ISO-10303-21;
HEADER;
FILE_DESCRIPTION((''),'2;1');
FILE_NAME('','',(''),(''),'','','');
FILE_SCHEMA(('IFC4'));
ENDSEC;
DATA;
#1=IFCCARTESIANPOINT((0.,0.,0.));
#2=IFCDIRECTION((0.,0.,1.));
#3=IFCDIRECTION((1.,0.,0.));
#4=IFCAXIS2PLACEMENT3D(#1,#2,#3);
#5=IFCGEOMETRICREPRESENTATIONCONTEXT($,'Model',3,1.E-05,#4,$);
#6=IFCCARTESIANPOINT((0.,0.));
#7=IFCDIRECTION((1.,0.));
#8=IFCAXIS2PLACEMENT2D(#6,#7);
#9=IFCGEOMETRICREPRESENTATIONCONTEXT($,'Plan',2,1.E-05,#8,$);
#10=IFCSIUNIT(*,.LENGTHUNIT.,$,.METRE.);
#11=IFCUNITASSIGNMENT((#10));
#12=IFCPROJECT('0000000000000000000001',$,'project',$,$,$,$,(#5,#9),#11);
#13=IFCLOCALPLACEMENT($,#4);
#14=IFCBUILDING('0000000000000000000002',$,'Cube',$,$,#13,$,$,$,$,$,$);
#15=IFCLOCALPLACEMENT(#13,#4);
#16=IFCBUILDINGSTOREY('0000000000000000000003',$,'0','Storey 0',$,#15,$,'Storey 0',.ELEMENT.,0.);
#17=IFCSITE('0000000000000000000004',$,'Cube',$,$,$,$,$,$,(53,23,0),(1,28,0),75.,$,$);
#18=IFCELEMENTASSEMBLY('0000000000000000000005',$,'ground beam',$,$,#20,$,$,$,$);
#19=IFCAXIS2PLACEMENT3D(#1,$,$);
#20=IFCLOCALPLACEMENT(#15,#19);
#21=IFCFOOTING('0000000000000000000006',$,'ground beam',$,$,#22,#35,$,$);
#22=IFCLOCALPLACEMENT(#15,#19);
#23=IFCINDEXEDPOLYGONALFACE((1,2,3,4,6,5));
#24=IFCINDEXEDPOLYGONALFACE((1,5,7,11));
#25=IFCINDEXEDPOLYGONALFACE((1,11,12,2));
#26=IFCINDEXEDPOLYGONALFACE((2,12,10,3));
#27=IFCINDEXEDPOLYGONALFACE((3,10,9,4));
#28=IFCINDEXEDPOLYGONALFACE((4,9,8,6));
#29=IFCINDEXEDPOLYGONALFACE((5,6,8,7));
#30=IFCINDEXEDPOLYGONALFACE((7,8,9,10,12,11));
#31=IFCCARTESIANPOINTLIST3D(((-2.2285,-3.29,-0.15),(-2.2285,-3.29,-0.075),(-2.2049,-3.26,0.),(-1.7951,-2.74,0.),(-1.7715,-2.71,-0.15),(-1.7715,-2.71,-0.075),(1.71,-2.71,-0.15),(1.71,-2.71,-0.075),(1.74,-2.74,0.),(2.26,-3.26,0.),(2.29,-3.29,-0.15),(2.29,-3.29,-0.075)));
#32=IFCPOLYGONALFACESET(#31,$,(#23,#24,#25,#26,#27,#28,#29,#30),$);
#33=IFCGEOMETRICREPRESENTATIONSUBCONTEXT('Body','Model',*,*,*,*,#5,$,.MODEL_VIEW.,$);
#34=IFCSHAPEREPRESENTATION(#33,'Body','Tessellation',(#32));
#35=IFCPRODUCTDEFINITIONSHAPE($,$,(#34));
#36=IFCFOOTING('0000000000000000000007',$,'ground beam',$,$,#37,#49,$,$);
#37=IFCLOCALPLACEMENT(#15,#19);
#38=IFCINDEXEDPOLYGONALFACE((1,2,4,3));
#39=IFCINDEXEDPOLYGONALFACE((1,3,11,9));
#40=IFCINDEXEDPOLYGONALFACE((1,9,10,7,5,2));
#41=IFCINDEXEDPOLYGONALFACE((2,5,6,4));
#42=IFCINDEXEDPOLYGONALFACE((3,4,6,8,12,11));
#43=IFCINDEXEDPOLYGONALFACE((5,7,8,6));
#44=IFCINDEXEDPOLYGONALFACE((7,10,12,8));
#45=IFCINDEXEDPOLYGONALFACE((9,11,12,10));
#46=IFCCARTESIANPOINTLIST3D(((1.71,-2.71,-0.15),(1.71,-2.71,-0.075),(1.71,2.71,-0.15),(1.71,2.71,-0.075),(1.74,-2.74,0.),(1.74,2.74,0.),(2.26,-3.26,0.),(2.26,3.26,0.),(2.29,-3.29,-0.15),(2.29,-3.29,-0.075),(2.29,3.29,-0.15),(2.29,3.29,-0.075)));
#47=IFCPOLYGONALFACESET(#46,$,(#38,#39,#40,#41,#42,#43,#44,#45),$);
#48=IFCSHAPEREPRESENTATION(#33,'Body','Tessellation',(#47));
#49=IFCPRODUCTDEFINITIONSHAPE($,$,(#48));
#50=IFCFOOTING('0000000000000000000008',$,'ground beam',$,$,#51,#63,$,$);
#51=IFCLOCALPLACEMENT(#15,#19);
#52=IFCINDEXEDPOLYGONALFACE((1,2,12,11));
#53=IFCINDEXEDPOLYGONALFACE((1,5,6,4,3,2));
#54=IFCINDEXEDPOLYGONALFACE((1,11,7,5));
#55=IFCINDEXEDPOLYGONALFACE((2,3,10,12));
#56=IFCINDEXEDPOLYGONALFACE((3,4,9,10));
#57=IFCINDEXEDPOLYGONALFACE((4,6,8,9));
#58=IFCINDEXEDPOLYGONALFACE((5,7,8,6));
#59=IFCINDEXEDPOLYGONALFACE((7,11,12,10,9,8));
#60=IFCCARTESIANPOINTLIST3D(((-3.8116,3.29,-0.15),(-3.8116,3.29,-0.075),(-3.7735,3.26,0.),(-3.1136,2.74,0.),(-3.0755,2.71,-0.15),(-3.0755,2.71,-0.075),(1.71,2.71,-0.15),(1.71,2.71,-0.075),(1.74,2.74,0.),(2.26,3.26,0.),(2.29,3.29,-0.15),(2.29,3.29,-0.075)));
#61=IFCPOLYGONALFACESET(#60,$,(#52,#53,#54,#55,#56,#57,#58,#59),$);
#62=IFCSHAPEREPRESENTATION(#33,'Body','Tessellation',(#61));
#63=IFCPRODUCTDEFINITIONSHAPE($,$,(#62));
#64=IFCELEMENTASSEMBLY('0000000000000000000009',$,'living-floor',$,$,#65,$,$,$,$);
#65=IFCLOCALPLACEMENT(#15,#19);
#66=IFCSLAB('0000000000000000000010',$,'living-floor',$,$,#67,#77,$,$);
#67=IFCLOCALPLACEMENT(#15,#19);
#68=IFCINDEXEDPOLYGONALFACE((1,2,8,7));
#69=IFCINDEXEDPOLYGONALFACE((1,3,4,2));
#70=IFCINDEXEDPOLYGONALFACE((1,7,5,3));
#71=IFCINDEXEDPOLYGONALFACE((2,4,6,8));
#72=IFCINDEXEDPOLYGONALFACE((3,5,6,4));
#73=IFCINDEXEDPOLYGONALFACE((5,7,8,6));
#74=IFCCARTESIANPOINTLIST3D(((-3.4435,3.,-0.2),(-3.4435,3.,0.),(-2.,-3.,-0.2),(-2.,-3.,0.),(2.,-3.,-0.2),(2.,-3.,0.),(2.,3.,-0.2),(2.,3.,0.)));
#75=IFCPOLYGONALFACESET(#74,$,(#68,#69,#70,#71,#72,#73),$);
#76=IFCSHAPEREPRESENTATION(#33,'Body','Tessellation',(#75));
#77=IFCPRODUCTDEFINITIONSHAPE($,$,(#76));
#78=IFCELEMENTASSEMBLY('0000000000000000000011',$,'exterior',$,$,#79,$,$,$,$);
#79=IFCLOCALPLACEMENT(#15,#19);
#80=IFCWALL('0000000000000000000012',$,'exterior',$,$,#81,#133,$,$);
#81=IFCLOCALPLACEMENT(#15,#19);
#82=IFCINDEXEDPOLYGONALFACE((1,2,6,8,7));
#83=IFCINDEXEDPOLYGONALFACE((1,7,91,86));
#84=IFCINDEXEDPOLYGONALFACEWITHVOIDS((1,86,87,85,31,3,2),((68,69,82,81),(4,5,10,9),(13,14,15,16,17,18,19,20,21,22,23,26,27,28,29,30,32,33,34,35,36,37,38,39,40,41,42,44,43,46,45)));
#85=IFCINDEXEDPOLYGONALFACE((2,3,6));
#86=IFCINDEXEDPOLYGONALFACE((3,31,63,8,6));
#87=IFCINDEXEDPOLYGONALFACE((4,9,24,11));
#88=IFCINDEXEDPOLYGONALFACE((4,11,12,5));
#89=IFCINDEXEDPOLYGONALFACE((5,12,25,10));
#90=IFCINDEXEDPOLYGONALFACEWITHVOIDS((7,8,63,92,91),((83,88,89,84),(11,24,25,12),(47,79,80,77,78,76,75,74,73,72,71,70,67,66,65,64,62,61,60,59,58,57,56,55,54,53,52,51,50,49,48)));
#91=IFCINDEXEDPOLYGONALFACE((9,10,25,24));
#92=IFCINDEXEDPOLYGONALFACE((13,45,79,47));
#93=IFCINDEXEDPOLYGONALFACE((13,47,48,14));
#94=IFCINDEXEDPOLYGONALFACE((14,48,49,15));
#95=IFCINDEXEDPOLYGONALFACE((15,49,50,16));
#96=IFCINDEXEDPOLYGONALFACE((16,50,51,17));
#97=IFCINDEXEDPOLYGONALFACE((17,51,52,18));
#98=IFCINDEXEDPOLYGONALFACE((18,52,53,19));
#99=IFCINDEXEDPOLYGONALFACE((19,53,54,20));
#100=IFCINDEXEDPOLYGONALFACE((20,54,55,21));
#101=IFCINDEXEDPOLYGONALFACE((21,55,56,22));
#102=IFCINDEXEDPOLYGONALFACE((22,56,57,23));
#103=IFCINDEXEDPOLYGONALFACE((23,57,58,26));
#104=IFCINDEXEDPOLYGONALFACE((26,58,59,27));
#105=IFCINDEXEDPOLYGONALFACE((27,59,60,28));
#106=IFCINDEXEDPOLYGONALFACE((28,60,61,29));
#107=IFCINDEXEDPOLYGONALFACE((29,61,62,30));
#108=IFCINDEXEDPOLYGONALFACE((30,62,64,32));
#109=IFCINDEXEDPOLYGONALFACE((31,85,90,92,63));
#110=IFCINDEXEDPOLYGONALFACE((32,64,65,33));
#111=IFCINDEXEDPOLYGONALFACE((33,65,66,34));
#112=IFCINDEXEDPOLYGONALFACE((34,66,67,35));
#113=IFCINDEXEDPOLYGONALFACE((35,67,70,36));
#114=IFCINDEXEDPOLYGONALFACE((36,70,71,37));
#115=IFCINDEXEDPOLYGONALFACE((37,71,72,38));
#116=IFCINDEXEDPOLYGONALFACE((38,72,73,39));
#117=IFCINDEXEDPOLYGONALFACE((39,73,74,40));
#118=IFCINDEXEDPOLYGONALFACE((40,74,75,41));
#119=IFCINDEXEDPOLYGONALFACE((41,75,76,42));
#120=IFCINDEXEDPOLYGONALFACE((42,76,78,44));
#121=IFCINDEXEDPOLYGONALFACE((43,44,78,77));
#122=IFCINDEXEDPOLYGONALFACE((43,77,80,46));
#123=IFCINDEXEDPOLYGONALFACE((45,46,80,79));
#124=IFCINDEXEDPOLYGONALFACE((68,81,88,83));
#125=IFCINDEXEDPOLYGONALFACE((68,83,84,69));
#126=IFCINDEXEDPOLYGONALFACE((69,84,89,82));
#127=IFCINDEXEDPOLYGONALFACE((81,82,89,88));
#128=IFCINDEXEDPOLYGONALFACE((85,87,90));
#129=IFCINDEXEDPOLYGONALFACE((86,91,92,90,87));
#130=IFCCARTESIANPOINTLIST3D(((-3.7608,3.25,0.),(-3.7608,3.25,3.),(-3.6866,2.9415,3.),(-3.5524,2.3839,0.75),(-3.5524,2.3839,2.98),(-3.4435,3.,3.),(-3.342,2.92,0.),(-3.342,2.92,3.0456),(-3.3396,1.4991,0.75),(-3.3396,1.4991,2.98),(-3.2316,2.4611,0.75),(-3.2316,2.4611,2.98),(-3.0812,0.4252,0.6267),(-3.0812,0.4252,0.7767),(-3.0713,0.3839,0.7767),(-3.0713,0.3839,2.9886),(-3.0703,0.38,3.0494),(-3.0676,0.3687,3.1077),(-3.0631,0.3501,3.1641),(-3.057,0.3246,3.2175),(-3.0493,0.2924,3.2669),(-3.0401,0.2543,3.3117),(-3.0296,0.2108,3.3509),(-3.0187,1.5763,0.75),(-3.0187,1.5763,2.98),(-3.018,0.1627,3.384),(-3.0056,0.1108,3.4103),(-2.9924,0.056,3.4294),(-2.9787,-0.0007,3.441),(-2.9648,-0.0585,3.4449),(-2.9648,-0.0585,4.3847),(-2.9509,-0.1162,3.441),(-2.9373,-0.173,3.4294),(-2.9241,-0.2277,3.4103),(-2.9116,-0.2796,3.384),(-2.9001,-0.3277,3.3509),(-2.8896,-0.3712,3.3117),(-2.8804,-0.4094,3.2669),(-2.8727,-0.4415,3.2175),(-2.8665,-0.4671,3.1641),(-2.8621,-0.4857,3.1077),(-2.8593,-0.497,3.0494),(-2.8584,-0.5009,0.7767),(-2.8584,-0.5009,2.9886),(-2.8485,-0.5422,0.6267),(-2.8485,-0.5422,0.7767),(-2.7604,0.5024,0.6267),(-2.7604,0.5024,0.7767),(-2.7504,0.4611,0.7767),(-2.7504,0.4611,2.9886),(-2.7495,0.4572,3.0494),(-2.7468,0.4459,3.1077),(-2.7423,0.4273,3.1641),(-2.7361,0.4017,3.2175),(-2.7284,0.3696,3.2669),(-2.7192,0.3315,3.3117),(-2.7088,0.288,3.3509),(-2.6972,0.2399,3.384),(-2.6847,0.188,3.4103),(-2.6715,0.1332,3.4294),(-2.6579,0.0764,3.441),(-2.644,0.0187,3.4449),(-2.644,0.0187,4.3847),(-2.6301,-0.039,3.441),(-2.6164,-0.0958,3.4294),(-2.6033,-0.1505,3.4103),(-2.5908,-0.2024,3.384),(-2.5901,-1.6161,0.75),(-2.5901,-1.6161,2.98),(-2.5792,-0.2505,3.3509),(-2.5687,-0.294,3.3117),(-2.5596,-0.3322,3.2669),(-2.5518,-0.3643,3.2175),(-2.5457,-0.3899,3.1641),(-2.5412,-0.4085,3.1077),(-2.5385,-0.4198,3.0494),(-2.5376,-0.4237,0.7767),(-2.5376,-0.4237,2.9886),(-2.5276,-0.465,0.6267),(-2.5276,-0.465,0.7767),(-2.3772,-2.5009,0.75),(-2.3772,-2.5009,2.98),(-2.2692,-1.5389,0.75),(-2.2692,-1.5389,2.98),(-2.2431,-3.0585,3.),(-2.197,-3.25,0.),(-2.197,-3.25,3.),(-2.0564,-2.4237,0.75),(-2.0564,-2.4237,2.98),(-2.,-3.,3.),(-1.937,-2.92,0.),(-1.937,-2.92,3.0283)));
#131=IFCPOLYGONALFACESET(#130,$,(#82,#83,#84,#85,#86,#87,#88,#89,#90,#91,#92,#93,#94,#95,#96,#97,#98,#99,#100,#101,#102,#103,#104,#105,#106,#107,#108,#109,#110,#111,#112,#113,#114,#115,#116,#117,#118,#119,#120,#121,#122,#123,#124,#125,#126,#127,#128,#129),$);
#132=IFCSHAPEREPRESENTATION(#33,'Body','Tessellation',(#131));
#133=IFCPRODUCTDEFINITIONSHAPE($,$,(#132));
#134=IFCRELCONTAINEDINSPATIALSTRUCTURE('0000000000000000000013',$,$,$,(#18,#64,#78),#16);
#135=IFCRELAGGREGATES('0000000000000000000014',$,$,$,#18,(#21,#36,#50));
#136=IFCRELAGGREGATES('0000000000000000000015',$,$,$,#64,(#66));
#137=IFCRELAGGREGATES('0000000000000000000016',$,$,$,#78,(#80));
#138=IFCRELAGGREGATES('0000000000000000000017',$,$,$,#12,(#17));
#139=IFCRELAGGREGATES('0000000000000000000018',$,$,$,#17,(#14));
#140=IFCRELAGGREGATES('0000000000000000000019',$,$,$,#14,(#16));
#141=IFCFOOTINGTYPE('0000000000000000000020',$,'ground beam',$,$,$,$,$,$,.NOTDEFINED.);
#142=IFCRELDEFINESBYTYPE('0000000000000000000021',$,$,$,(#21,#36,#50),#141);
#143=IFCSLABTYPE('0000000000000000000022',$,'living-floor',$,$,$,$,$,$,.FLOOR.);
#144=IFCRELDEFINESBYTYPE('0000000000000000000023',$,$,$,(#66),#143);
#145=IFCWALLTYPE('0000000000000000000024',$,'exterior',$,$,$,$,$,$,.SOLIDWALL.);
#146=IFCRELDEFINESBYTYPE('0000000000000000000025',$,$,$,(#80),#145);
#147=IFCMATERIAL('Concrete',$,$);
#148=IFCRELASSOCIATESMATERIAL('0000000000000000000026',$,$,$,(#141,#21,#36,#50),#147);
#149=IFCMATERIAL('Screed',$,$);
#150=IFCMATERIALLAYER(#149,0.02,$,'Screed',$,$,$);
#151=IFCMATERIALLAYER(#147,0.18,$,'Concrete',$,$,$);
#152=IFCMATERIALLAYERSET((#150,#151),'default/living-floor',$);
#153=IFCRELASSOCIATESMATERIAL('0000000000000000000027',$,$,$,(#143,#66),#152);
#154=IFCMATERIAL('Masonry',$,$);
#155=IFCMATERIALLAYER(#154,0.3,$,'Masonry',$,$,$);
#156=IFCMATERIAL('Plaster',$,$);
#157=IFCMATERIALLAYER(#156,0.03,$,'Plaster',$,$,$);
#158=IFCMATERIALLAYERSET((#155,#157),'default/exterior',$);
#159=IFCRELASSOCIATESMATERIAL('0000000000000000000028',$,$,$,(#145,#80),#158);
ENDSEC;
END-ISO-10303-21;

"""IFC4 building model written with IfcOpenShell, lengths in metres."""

from ifc_helpers import new_model, si_unit, frame, origin, origin_with_axes, origin_2d_with_axis, place, context, subcontext, project, spatial, polyline, outline, extrude, clip, halfspace, bounded_halfspace, material, layer, layer_set, layer_usage, material_profile, profile_set, profile_usage, type_object, element, aggregate, save


model = new_model("IFC4")

# Units and contexts
model_context = context("Model", 3, precision=1e-05, world=origin_with_axes())
plan_context = context("Plan", 2, precision=1e-05, world=origin_2d_with_axis())
body_context = subcontext(model_context, "Body", "Model", "MODEL_VIEW")
ifc_project = project(units=[si_unit("LENGTHUNIT", "METRE")], contexts=[model_context, plan_context])

# Site, building, storey
site = spatial("IfcSite", under=ifc_project, Name="Cube", RefLatitude=(53, 23, 0), RefLongitude=(1, 28, 0), RefElevation=75.0)
building_placement = place(None, origin_with_axes())
building = spatial("IfcBuilding", under=site, at=building_placement, Name="Cube")
storey_placement = place(building_placement, origin_with_axes())
storey = spatial("IfcBuildingStorey", under=building, at=storey_placement, Name="0", Description="Storey 0", LongName="Storey 0", CompositionType="ELEMENT", Elevation=0.0)

# Element assembly, footings
assembly_1_placement = place(storey_placement, origin_with_axes())
assembly_1 = element("IfcElementAssembly", 1, at=assembly_1_placement, inside=storey, Name="ground beam")
ifc_material_1 = material(Name="Concrete")
ifc_material_profile = material_profile(ifc_material_1, outline(polyline([(-0.26, 0.0), (-0.29, -0.075), (-0.29, -0.15), (0.29, -0.15), (0.29, -0.075), (0.26, 0.0), (-0.26, 0.0)])))
ifc_profile_set = profile_set([ifc_material_profile])
ifc_profile_usage_1 = profile_usage(ifc_profile_set)
footing_type = type_object("IfcFootingType", Name="ground beam", PredefinedType="NOTDEFINED", material=ifc_profile_set)
footing_1_placement = place(assembly_1_placement, frame((3.0, -3.0, 0.0), z_axis=(-1.0, 0.0, 0.0), x_axis=(0.0, -1.0, 0.0)))
footing_1 = element("IfcFooting", 2, at=footing_1_placement, type_object=footing_type, material=ifc_profile_usage_1, Name="ground beam", context=body_context, shape_type="Clipping", body=[
    clip(clip(extrude(outline(polyline([(-0.26, 0.0), (-0.29, -0.075), (-0.29, -0.15), (0.29, -0.15), (0.29, -0.075), (0.26, 0.0), (-0.26, 0.0)])), origin_with_axes(), (0.0, 0.0, 1.0), 6.0), halfspace(frame((0.0, 0.0, 1.0), z_axis=(-0.707107, 0.0, -0.707107), x_axis=(0.0, 1.0, 0.0)), False)), halfspace(frame((0.0, 0.0, 5.0), z_axis=(-0.618904, 0.0, 0.785467), x_axis=(0.0, 1.0, 0.0)), False)),
])
ifc_profile_usage_2 = profile_usage(ifc_profile_set)
footing_2_placement = place(assembly_1_placement, frame((2.0, 4.0, 0.0), z_axis=(0.0, -1.0, 0.0), x_axis=(1.0, 0.0, 0.0)))
footing_2 = element("IfcFooting", 3, at=footing_2_placement, type_object=footing_type, material=ifc_profile_usage_2, Name="ground beam", context=body_context, shape_type="Clipping", body=[
    clip(clip(extrude(outline(polyline([(-0.26, 0.0), (-0.29, -0.075), (-0.29, -0.15), (0.29, -0.15), (0.29, -0.075), (0.26, 0.0), (-0.26, 0.0)])), origin_with_axes(), (0.0, 0.0, 1.0), 8.0), halfspace(frame((0.0, 0.0, 1.0), z_axis=(-0.707107, 0.0, -0.707107), x_axis=(0.0, 1.0, 0.0)), False)), halfspace(frame((0.0, 0.0, 7.0), z_axis=(-0.707107, 0.0, 0.707107), x_axis=(0.0, 1.0, 0.0)), False)),
])
ifc_profile_usage_3 = profile_usage(ifc_profile_set)
footing_3_placement = place(assembly_1_placement, frame((-4.4435, 3.0, 0.0), z_axis=(1.0, 0.0, 0.0), x_axis=(0.0, 1.0, 0.0)))
footing_3 = element("IfcFooting", 4, at=footing_3_placement, type_object=footing_type, material=ifc_profile_usage_3, Name="ground beam", context=body_context, shape_type="Clipping", body=[
    clip(clip(extrude(outline(polyline([(-0.26, 0.0), (-0.29, -0.075), (-0.29, -0.15), (0.29, -0.15), (0.29, -0.075), (0.26, 0.0), (-0.26, 0.0)])), origin_with_axes(), (0.0, 0.0, 1.0), 7.4435), halfspace(frame((0.0, 0.0, 1.0), z_axis=(-0.785467, 0.0, -0.618904), x_axis=(0.0, 1.0, 0.0)), False)), halfspace(frame((0.0, 0.0, 6.4435), z_axis=(-0.707107, 0.0, 0.707107), x_axis=(0.0, 1.0, 0.0)), False)),
])
aggregate(assembly_1, [footing_1, footing_2, footing_3])

# Element assembly, slab
assembly_2_placement = place(storey_placement, origin_with_axes())
assembly_2 = element("IfcElementAssembly", 5, at=assembly_2_placement, inside=storey, Name="living-floor")
ifc_material_2 = material(Name="Screed")
ifc_layer_1 = layer(ifc_material_2, 0.02, Name="Screed")
ifc_layer_2 = layer(ifc_material_1, 0.18, Name="Concrete")
ifc_layer_set_1 = layer_set([ifc_layer_1, ifc_layer_2], Name="default/living-floor")
ifc_layer_usage_1 = layer_usage(ifc_layer_set_1, "AXIS3", "POSITIVE", 0.0)
slab_type = type_object("IfcSlabType", Name="living-floor", PredefinedType="FLOOR", material=ifc_layer_set_1)
slab_placement = place(assembly_2_placement, frame((2.0, 3.0, -0.2), z_axis=(0.0, 0.0, -1.0), x_axis=(0.0, 1.0, 0.0)))
slab = element("IfcSlab", 6, at=slab_placement, type_object=slab_type, material=ifc_layer_usage_1, Name="living-floor", context=body_context, shape_type="SweptSolid", body=[
    extrude(outline(polyline([(0.0, 0.0), (-6.0, 0.0), (-6.0, -4.0), (0.0, -5.4435), (0.0, 0.0)])), origin(), (0.0, 0.0, -1.0), 0.2),
])
aggregate(assembly_2, [slab])

# Element assembly, wall, openings
assembly_3_placement = place(storey_placement, frame((-3.4435, 3.0, 0.0), z_axis=(0.0, 0.0, 1.0), x_axis=(0.233915, -0.972257, 0.0)))
assembly_3 = element("IfcElementAssembly", 7, at=assembly_3_placement, inside=storey, Name="exterior")
ifc_material_3 = material(Name="Masonry")
ifc_layer_3 = layer(ifc_material_3, 0.3, Name="Masonry")
ifc_material_4 = material(Name="Plaster")
ifc_layer_4 = layer(ifc_material_4, 0.03, Name="Plaster")
ifc_layer_set_2 = layer_set([ifc_layer_3, ifc_layer_4], Name="default/exterior")
ifc_layer_usage_2 = layer_usage(ifc_layer_set_2, "AXIS2", "POSITIVE", -0.25)
wall_type = type_object("IfcWallType", Name="exterior", PredefinedType="SOLIDWALL", material=ifc_layer_set_2)
wall_1_placement = place(assembly_3_placement, frame((0.0, 0.0, 0.0), z_axis=(0.0, 0.0, 1.0), x_axis=(1.0, 0.0, 0.0)))
wall_1 = element("IfcWall", 8, at=wall_1_placement, type_object=wall_type, material=ifc_layer_usage_2, Name="exterior", context=body_context, shape_type="Clipping", body=[
    clip(clip(clip(clip(extrude(outline(polyline([(0.1015, 0.08), (-0.3173, -0.25), (6.3682, -0.25), (6.1082, 0.08), (0.1015, 0.08)])), origin(), (0.0, 0.0, 1.0), 4.385), bounded_halfspace(frame((6.1712, 0.0, 3.0), z_axis=(0.409415, 0.0, 0.912348), x_axis=(0.0, -1.0, 0.0)), False, origin(), polyline([(6.1712, -1.0), (3.0856, -1.0), (3.0856, 1.0), (6.1712, 1.0), (6.1712, -1.0)]))), bounded_halfspace(frame((6.1712, 0.0, 3.0), z_axis=(0.0, 0.0, 1.0), x_axis=(0.0, 1.0, 0.0)), False, origin(), polyline([(6.1712, 1.0), (7.1712, 1.0), (7.1712, -1.0), (6.1712, -1.0), (6.1712, 1.0)]))), bounded_halfspace(frame((3.0856, 0.0, 4.3847), z_axis=(-0.409415, 0.0, 0.912348), x_axis=(0.0, -1.0, 0.0)), False, origin(), polyline([(3.0856, -1.0), (0.0, -1.0), (0.0, 1.0), (3.0856, 1.0), (3.0856, -1.0)]))), bounded_halfspace(frame((0.0, 0.0, 3.0), z_axis=(0.0, 0.0, 1.0), x_axis=(0.0, -1.0, 0.0)), False, origin(), polyline([(0.0, -1.0), (-1.0, -1.0), (-1.0, 1.0), (0.0, 1.0), (0.0, -1.0)]))),
])
opening_1_placement = place(wall_1_placement, frame((0.5735, -0.25, 0.75), z_axis=(0.0, 0.0, 1.0), x_axis=(1.0, 0.0, 0.0)))
element("IfcOpeningElement", 9, at=opening_1_placement, cuts=wall_1, PredefinedType="OPENING", context=body_context, shape_type="SweptSolid", body=[
    extrude(outline(polyline([(0.0, -0.02), (0.91, -0.02), (0.91, 0.35), (0.0, 0.35), (0.0, -0.02)])), origin(), (0.0, 0.0, 1.0), 2.23),
])
opening_2_placement = place(wall_1_placement, frame((2.6306, -0.25, 0.75), z_axis=(0.0, 0.0, 1.0), x_axis=(1.0, 0.0, 0.0)))
element("IfcOpeningElement", 10, at=opening_2_placement, cuts=wall_1, PredefinedType="OPENING", context=body_context, shape_type="SweptSolid", body=[
    extrude(outline(polyline([(0.1333, 2.5617), (0.1781, 2.6009), (0.2275, 2.634), (0.2809, 2.6603), (0.3373, 2.6794), (0.3956, 2.691), (0.455, 2.6949), (0.5144, 2.691), (0.5727, 2.6794), (0.6291, 2.6603), (0.6825, 2.634), (0.7319, 2.6009), (0.7767, 2.5617), (0.8159, 2.5169), (0.849, 2.4675), (0.8753, 2.4141), (0.8944, 2.3577), (0.906, 2.2994), (0.91, 2.2386), (0.91, 2.2069), (0.91, 0.0267), (0.9525, 0.0267), (0.9525, -0.1233), (-0.0425, -0.1233), (-0.0425, 0.0267), (0.0, 0.0267), (0.0, 2.2069), (0.0, 2.2386), (0.004, 2.2994), (0.0156, 2.3577), (0.0347, 2.4141), (0.061, 2.4675), (0.0941, 2.5169), (0.1333, 2.5617)])), frame((0.0, -0.02, 0.0), z_axis=(0.0, -1.0, 0.0), x_axis=(1.0, 0.0, 0.0)), (0.0, 0.0, -1.0), 0.37),
])
opening_3_placement = place(wall_1_placement, frame((4.6877, -0.25, 0.75), z_axis=(0.0, 0.0, 1.0), x_axis=(1.0, 0.0, 0.0)))
element("IfcOpeningElement", 11, at=opening_3_placement, cuts=wall_1, PredefinedType="OPENING", context=body_context, shape_type="SweptSolid", body=[
    extrude(outline(polyline([(0.0, -0.02), (0.91, -0.02), (0.91, 0.35), (0.0, 0.35), (0.0, -0.02)])), origin(), (0.0, 0.0, 1.0), 2.23),
])
aggregate(assembly_3, [wall_1])

save(model, "model.ifc")
